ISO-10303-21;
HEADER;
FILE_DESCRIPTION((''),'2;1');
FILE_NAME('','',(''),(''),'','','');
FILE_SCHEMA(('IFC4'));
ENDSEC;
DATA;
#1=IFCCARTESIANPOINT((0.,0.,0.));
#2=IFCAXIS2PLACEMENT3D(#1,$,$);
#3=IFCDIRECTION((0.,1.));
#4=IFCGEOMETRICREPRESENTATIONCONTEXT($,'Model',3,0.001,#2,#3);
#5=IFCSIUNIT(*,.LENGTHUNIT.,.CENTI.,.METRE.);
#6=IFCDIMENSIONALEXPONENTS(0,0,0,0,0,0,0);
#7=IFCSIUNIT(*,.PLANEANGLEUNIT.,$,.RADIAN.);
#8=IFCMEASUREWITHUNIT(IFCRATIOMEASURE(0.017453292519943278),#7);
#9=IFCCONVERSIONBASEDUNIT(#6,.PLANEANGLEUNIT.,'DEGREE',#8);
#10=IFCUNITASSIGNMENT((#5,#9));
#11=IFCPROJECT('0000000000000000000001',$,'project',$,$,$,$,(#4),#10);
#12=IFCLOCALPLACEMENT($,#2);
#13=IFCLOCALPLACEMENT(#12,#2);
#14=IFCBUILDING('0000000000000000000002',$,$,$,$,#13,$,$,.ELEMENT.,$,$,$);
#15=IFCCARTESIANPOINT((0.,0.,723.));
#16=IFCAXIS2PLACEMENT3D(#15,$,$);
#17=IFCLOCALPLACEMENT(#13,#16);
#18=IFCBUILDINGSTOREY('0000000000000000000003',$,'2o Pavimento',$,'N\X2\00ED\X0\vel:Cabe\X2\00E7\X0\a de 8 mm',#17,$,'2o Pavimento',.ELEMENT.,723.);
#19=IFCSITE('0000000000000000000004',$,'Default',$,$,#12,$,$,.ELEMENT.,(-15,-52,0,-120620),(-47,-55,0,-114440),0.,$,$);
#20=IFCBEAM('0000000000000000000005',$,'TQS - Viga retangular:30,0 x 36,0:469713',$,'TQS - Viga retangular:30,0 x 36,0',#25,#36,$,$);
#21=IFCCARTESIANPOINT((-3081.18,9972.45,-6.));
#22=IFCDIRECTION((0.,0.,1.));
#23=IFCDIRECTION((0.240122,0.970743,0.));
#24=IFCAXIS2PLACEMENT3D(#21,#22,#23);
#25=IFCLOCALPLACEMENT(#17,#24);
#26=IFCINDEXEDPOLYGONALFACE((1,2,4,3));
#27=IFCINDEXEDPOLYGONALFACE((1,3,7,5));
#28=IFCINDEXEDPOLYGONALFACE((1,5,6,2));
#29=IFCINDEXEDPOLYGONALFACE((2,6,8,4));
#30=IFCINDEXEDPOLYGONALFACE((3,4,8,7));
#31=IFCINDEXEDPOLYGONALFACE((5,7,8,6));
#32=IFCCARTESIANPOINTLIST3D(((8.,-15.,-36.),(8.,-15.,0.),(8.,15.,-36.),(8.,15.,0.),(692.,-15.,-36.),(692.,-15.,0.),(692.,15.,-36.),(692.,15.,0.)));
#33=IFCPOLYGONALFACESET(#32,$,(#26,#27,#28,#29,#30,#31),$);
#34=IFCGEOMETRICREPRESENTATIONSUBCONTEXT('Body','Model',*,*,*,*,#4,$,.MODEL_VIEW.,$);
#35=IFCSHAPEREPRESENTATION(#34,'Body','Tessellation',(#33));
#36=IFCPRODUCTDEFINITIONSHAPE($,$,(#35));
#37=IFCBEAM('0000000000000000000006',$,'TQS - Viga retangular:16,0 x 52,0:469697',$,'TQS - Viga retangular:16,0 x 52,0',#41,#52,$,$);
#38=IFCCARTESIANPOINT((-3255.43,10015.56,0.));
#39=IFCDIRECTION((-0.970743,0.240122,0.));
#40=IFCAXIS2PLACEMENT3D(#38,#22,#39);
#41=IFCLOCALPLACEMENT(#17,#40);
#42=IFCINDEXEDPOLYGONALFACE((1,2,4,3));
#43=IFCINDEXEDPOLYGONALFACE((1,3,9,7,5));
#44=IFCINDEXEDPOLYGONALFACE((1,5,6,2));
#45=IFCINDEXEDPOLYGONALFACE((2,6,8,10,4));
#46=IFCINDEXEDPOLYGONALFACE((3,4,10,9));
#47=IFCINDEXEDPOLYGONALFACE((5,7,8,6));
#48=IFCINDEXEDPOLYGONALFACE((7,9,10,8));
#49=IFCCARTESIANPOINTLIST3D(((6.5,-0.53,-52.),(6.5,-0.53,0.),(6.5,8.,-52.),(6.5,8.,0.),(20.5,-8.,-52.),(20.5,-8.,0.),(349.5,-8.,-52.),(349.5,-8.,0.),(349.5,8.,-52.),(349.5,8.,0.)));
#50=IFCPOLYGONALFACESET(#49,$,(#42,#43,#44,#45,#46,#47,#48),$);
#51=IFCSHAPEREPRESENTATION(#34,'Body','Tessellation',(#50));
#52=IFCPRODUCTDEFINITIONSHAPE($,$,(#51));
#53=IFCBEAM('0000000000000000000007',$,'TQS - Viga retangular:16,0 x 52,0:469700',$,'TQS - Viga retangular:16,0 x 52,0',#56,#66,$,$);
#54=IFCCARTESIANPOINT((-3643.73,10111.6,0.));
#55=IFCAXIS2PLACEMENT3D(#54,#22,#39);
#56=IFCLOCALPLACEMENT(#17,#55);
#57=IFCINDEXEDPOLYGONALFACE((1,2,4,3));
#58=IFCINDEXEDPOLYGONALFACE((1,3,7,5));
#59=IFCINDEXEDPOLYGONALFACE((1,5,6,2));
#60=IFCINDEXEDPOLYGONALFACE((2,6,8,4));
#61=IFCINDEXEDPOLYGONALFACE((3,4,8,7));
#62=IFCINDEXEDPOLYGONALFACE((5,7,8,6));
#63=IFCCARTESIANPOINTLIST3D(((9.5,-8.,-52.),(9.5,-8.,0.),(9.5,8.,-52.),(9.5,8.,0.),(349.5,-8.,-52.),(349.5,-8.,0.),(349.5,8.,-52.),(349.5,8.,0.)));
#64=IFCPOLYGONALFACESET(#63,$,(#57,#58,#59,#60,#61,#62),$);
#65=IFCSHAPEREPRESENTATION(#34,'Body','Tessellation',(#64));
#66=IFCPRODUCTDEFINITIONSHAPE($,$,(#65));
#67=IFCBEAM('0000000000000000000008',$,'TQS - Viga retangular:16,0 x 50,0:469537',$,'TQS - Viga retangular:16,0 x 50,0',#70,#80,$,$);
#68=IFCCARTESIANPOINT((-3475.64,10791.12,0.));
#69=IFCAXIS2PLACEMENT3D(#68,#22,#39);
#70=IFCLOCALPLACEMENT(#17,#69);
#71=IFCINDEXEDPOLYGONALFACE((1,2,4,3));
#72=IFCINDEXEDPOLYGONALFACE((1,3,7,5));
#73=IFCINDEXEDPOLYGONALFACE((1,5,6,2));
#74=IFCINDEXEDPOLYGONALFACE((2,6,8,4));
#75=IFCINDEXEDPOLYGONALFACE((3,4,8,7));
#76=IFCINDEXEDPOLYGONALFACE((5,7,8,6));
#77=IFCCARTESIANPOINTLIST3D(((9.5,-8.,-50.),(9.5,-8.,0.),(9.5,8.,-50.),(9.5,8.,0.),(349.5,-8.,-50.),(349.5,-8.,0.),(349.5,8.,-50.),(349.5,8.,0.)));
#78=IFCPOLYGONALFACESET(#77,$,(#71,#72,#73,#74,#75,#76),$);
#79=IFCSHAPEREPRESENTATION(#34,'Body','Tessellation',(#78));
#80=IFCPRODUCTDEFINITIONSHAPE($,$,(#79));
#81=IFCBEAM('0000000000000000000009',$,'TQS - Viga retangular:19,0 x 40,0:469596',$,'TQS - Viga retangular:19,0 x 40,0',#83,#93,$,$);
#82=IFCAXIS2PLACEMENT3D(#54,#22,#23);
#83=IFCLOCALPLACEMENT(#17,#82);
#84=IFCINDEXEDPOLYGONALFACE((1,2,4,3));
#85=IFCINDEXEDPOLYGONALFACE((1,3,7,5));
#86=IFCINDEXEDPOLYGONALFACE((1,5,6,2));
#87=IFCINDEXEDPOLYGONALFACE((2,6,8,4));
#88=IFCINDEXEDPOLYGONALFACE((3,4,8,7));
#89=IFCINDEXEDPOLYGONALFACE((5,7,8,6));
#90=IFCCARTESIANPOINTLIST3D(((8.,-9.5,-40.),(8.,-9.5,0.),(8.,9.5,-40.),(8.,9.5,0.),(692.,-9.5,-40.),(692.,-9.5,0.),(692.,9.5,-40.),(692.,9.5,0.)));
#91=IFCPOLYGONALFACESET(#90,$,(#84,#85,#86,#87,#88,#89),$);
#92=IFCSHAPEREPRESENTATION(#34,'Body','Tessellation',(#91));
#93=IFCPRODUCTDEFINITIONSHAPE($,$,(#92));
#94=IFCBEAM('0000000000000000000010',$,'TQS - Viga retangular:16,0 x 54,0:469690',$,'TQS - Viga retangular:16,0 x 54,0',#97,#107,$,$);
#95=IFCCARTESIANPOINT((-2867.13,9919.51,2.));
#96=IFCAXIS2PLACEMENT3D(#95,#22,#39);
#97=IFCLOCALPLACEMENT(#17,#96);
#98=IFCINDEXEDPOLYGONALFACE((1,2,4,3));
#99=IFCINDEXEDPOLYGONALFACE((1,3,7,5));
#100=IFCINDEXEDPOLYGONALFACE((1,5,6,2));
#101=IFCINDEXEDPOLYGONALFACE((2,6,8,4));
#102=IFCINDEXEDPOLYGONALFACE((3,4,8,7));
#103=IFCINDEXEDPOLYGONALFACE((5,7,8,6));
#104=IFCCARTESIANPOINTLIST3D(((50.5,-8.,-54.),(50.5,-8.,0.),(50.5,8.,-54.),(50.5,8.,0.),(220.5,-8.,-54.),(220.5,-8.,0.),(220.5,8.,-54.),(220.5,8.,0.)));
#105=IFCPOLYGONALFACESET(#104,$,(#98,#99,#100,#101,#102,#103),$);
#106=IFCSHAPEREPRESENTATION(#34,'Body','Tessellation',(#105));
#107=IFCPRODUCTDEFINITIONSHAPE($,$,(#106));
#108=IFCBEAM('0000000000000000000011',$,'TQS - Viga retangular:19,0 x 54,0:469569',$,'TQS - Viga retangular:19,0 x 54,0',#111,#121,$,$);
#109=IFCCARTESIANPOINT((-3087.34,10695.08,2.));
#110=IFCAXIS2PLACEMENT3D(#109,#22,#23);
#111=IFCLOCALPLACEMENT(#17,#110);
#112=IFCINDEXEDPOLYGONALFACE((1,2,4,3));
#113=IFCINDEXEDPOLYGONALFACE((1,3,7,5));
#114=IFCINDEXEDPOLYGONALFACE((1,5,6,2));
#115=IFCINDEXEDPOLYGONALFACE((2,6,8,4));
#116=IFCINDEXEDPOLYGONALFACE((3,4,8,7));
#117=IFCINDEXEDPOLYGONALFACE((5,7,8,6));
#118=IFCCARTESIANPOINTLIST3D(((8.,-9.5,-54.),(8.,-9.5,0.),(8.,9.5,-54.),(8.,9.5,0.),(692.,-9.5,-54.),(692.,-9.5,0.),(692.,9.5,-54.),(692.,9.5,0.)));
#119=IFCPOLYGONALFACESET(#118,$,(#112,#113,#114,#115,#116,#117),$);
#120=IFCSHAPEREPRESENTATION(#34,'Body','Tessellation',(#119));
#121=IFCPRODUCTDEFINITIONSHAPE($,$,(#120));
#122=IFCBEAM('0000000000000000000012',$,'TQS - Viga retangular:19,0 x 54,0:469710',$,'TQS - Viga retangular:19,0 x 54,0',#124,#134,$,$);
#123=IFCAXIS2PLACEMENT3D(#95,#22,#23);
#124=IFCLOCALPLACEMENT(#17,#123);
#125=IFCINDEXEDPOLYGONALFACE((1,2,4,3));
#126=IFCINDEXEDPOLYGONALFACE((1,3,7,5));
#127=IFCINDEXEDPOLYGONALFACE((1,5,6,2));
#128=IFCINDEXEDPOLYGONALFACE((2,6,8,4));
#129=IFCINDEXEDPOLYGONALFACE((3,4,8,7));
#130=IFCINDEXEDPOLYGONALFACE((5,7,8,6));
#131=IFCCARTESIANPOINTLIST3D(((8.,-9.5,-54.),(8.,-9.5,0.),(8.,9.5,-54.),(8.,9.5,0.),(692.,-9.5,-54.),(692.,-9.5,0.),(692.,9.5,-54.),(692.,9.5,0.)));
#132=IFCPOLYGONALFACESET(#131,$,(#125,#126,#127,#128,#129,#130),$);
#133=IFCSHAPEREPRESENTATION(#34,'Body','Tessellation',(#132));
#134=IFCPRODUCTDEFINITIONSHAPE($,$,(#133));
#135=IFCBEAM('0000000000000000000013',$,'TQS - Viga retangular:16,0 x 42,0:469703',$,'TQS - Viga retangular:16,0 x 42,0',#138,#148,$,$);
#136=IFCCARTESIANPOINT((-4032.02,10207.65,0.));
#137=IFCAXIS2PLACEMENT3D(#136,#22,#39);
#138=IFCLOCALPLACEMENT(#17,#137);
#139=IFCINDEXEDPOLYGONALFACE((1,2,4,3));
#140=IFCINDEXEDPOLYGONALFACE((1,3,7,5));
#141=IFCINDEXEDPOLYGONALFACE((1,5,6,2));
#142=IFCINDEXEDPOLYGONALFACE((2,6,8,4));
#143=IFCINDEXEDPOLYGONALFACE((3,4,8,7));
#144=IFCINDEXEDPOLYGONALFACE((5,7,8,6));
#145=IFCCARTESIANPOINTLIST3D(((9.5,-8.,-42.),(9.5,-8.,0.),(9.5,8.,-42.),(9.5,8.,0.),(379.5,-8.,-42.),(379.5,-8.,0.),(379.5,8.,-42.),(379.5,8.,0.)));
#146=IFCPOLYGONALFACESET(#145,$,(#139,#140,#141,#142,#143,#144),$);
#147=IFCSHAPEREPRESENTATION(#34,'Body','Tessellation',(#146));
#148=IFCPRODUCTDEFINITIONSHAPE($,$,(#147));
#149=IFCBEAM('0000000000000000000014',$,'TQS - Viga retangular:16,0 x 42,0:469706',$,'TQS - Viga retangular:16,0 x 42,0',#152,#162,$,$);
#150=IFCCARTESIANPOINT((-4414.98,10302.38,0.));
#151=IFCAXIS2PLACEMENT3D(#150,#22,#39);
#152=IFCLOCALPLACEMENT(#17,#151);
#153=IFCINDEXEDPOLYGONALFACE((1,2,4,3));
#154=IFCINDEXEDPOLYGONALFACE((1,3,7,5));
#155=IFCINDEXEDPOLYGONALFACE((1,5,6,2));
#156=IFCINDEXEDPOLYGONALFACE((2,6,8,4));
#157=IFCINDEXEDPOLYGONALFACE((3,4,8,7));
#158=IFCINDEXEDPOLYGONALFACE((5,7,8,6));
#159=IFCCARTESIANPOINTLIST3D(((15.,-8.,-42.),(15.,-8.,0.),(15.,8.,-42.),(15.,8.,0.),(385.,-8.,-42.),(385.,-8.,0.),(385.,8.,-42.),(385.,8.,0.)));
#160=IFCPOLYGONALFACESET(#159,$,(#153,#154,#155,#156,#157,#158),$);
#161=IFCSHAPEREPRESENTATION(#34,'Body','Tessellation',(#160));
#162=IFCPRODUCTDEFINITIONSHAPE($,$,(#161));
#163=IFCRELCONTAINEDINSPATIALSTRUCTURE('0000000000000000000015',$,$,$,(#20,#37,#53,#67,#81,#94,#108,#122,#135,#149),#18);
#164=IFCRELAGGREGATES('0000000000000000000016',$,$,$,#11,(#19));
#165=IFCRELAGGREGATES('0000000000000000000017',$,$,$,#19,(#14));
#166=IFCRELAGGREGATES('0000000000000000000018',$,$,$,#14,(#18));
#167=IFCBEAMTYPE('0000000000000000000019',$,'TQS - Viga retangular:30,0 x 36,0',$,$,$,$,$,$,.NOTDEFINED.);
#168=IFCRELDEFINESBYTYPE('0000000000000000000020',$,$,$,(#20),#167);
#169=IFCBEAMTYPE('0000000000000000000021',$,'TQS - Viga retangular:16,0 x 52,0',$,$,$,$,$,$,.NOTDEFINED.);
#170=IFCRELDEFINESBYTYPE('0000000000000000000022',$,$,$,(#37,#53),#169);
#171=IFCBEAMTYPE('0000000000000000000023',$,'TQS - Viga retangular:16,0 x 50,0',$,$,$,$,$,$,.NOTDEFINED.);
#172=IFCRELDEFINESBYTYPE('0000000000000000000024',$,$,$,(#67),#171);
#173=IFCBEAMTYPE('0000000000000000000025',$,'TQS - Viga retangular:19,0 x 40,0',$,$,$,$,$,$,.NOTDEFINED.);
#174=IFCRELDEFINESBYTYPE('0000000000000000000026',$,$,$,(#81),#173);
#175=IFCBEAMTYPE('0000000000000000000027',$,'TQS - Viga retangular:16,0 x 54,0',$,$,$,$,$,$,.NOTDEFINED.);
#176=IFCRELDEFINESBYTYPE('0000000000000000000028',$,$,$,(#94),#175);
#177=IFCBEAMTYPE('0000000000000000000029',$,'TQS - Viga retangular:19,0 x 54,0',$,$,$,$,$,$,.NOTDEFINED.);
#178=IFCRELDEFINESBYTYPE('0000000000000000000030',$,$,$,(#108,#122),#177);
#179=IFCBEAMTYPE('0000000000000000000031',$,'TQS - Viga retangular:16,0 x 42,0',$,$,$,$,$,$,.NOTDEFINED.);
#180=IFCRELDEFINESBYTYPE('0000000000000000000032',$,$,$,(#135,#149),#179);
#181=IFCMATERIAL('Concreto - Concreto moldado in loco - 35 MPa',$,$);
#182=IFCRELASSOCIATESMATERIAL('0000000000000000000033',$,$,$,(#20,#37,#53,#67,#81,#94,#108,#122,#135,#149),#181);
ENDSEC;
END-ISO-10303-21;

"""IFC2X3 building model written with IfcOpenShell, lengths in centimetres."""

from ifc_helpers import new_model, entity, si_unit, converted_unit, direction, frame, frame_2d, origin, origin_2d_with_axis, place, context, subcontext, project, spatial, rectangle, extrude, clip, halfspace, material, type_object, element, save


model = new_model("IFC2X3")

# Units and contexts
model_context = context("Model", 3, precision=0.001, world=origin(), true_north=direction((0.0, 1.0)))
body_context = subcontext(model_context, "Body", "Model", "MODEL_VIEW")
ifc_project = project(units=[si_unit("LENGTHUNIT", "METRE", prefix="CENTI"), converted_unit("PLANEANGLEUNIT", "DEGREE", entity("IfcRatioMeasure", 0.017453292519943278), si_unit("PLANEANGLEUNIT", "RADIAN"), dimensions=[0, 0, 0, 0, 0, 0, 0])], contexts=[model_context])

# Site, building, storey
site_placement = place(None, origin())
site = spatial("IfcSite", under=ifc_project, at=site_placement, Name="Default", CompositionType="ELEMENT", RefLatitude=(-15, -52, 0, -120620), RefLongitude=(-47, -55, 0, -114440), RefElevation=0.0)
building_placement = place(site_placement, origin())
building = spatial("IfcBuilding", under=site, at=building_placement, CompositionType="ELEMENT")
storey_placement = place(building_placement, frame((0.0, 0.0, 723.0)))
storey = spatial("IfcBuildingStorey", under=building, at=storey_placement, Name="2o Pavimento", ObjectType="Nível:Cabeça de 8 mm", LongName="2o Pavimento", CompositionType="ELEMENT", Elevation=723.0)

# Beams
ifc_material = material(Name="Concreto - Concreto moldado in loco - 35 MPa")
beam_type_1 = type_object("IfcBeamType", Name="TQS - Viga retangular:30,0 x 36,0", PredefinedType="NOTDEFINED")
beam_1_placement = place(storey_placement, frame((-3081.18, 9972.45, -6.0), z_axis=(0.0, 0.0, 1.0), x_axis=(0.240122, 0.970743, 0.0)))
element("IfcBeam", 1, at=beam_1_placement, inside=storey, type_object=beam_type_1, material=ifc_material, Name="TQS - Viga retangular:30,0 x 36,0:469713", ObjectType="TQS - Viga retangular:30,0 x 36,0", context=body_context, shape_type="SweptSolid", body=[
    extrude(rectangle(XDim=36.0, YDim=30.0, at=frame_2d((0.0, 0.0), x_axis=(1.0, 0.0))), frame((8.0, 0.0, -18.0), z_axis=(1.0, 0.0, 0.0), x_axis=(0.0, 0.0, -1.0)), (0.0, 0.0, 1.0), 684.0),
])
beam_type_2 = type_object("IfcBeamType", Name="TQS - Viga retangular:16,0 x 52,0", PredefinedType="NOTDEFINED")
beam_2_placement = place(storey_placement, frame((-3255.43, 10015.56, 0.0), z_axis=(0.0, 0.0, 1.0), x_axis=(-0.970743, 0.240122, 0.0)))
element("IfcBeam", 2, at=beam_2_placement, inside=storey, type_object=beam_type_2, material=ifc_material, Name="TQS - Viga retangular:16,0 x 52,0:469697", ObjectType="TQS - Viga retangular:16,0 x 52,0", context=body_context, shape_type="SweptSolid", body=[
    clip(extrude(rectangle(XDim=52.0, YDim=16.0, at=frame_2d((0.0, 0.0), x_axis=(1.0, 0.0))), frame((6.5, 0.0, -26.0), z_axis=(1.0, 0.0, 0.0), x_axis=(0.0, 0.0, -1.0)), (0.0, 0.0, 1.0), 343.0), halfspace(frame((20.5, -8.0, 0.0), z_axis=(-0.470588, -0.882353, 0.0), x_axis=(-0.882353, 0.470588, 0.0)), False)),
])
beam_3_placement = place(storey_placement, frame((-3643.73, 10111.6, 0.0), z_axis=(0.0, 0.0, 1.0), x_axis=(-0.970743, 0.240122, 0.0)))
element("IfcBeam", 3, at=beam_3_placement, inside=storey, type_object=beam_type_2, material=ifc_material, Name="TQS - Viga retangular:16,0 x 52,0:469700", ObjectType="TQS - Viga retangular:16,0 x 52,0", context=body_context, shape_type="SweptSolid", body=[
    extrude(rectangle(XDim=52.0, YDim=16.0, at=frame_2d((0.0, 0.0), x_axis=(1.0, 0.0))), frame((9.5, 0.0, -26.0), z_axis=(1.0, 0.0, 0.0), x_axis=(0.0, 0.0, -1.0)), (0.0, 0.0, 1.0), 340.0),
])
beam_type_3 = type_object("IfcBeamType", Name="TQS - Viga retangular:16,0 x 50,0", PredefinedType="NOTDEFINED")
beam_4_placement = place(storey_placement, frame((-3475.64, 10791.12, 0.0), z_axis=(0.0, 0.0, 1.0), x_axis=(-0.970743, 0.240122, 0.0)))
element("IfcBeam", 4, at=beam_4_placement, inside=storey, type_object=beam_type_3, material=ifc_material, Name="TQS - Viga retangular:16,0 x 50,0:469537", ObjectType="TQS - Viga retangular:16,0 x 50,0", context=body_context, shape_type="SweptSolid", body=[
    extrude(rectangle(XDim=50.0, YDim=16.0, at=frame_2d((0.0, 0.0), x_axis=(1.0, 0.0))), frame((9.5, 0.0, -25.0), z_axis=(1.0, 0.0, 0.0), x_axis=(0.0, 0.0, -1.0)), (0.0, 0.0, 1.0), 340.0),
])
beam_type_4 = type_object("IfcBeamType", Name="TQS - Viga retangular:19,0 x 40,0", PredefinedType="NOTDEFINED")
beam_5_placement = place(storey_placement, frame((-3643.73, 10111.6, 0.0), z_axis=(0.0, 0.0, 1.0), x_axis=(0.240122, 0.970743, 0.0)))
element("IfcBeam", 5, at=beam_5_placement, inside=storey, type_object=beam_type_4, material=ifc_material, Name="TQS - Viga retangular:19,0 x 40,0:469596", ObjectType="TQS - Viga retangular:19,0 x 40,0", context=body_context, shape_type="SweptSolid", body=[
    extrude(rectangle(XDim=40.0, YDim=19.0, at=origin_2d_with_axis()), frame((8.0, 0.0, -20.0), z_axis=(1.0, 0.0, 0.0), x_axis=(0.0, 0.0, -1.0)), (0.0, 0.0, 1.0), 684.0),
])
beam_type_5 = type_object("IfcBeamType", Name="TQS - Viga retangular:16,0 x 54,0", PredefinedType="NOTDEFINED")
beam_6_placement = place(storey_placement, frame((-2867.13, 9919.51, 2.0), z_axis=(0.0, 0.0, 1.0), x_axis=(-0.970743, 0.240122, 0.0)))
element("IfcBeam", 6, at=beam_6_placement, inside=storey, type_object=beam_type_5, material=ifc_material, Name="TQS - Viga retangular:16,0 x 54,0:469690", ObjectType="TQS - Viga retangular:16,0 x 54,0", context=body_context, shape_type="SweptSolid", body=[
    extrude(rectangle(XDim=54.0, YDim=16.0, at=frame_2d((0.0, 0.0), x_axis=(1.0, 0.0))), frame((50.5, 0.0, -27.0), z_axis=(1.0, 0.0, 0.0), x_axis=(0.0, 0.0, -1.0)), (0.0, 0.0, 1.0), 170.0),
])
beam_type_6 = type_object("IfcBeamType", Name="TQS - Viga retangular:19,0 x 54,0", PredefinedType="NOTDEFINED")
beam_7_placement = place(storey_placement, frame((-3087.34, 10695.08, 2.0), z_axis=(0.0, 0.0, 1.0), x_axis=(0.240122, 0.970743, 0.0)))
element("IfcBeam", 7, at=beam_7_placement, inside=storey, type_object=beam_type_6, material=ifc_material, Name="TQS - Viga retangular:19,0 x 54,0:469569", ObjectType="TQS - Viga retangular:19,0 x 54,0", context=body_context, shape_type="SweptSolid", body=[
    extrude(rectangle(XDim=54.0, YDim=19.0, at=frame_2d((0.0, 0.0), x_axis=(1.0, 0.0))), frame((8.0, 0.0, -27.0), z_axis=(1.0, 0.0, 0.0), x_axis=(0.0, 0.0, -1.0)), (0.0, 0.0, 1.0), 684.0),
])
beam_8_placement = place(storey_placement, frame((-2867.13, 9919.51, 2.0), z_axis=(0.0, 0.0, 1.0), x_axis=(0.240122, 0.970743, 0.0)))
element("IfcBeam", 8, at=beam_8_placement, inside=storey, type_object=beam_type_6, material=ifc_material, Name="TQS - Viga retangular:19,0 x 54,0:469710", ObjectType="TQS - Viga retangular:19,0 x 54,0", context=body_context, shape_type="SweptSolid", body=[
    extrude(rectangle(XDim=54.0, YDim=19.0, at=frame_2d((0.0, 0.0), x_axis=(1.0, 0.0))), frame((8.0, 0.0, -27.0), z_axis=(1.0, 0.0, 0.0), x_axis=(0.0, 0.0, -1.0)), (0.0, 0.0, 1.0), 684.0),
])
beam_type_7 = type_object("IfcBeamType", Name="TQS - Viga retangular:16,0 x 42,0", PredefinedType="NOTDEFINED")
beam_9_placement = place(storey_placement, frame((-4032.02, 10207.65, 0.0), z_axis=(0.0, 0.0, 1.0), x_axis=(-0.970743, 0.240122, 0.0)))
element("IfcBeam", 9, at=beam_9_placement, inside=storey, type_object=beam_type_7, material=ifc_material, Name="TQS - Viga retangular:16,0 x 42,0:469703", ObjectType="TQS - Viga retangular:16,0 x 42,0", context=body_context, shape_type="SweptSolid", body=[
    extrude(rectangle(XDim=42.0, YDim=16.0, at=frame_2d((0.0, 0.0), x_axis=(1.0, 0.0))), frame((9.5, 0.0, -21.0), z_axis=(1.0, 0.0, 0.0), x_axis=(0.0, 0.0, -1.0)), (0.0, 0.0, 1.0), 370.0),
])
beam_10_placement = place(storey_placement, frame((-4414.98, 10302.38, 0.0), z_axis=(0.0, 0.0, 1.0), x_axis=(-0.970743, 0.240122, 0.0)))
element("IfcBeam", 10, at=beam_10_placement, inside=storey, type_object=beam_type_7, material=ifc_material, Name="TQS - Viga retangular:16,0 x 42,0:469706", ObjectType="TQS - Viga retangular:16,0 x 42,0", context=body_context, shape_type="SweptSolid", body=[
    extrude(rectangle(XDim=42.0, YDim=16.0, at=frame_2d((0.0, 0.0), x_axis=(1.0, 0.0))), frame((15.0, 0.0, -21.0), z_axis=(1.0, 0.0, 0.0), x_axis=(0.0, 0.0, -1.0)), (0.0, 0.0, 1.0), 370.0),
])

save(model, "model.ifc")
